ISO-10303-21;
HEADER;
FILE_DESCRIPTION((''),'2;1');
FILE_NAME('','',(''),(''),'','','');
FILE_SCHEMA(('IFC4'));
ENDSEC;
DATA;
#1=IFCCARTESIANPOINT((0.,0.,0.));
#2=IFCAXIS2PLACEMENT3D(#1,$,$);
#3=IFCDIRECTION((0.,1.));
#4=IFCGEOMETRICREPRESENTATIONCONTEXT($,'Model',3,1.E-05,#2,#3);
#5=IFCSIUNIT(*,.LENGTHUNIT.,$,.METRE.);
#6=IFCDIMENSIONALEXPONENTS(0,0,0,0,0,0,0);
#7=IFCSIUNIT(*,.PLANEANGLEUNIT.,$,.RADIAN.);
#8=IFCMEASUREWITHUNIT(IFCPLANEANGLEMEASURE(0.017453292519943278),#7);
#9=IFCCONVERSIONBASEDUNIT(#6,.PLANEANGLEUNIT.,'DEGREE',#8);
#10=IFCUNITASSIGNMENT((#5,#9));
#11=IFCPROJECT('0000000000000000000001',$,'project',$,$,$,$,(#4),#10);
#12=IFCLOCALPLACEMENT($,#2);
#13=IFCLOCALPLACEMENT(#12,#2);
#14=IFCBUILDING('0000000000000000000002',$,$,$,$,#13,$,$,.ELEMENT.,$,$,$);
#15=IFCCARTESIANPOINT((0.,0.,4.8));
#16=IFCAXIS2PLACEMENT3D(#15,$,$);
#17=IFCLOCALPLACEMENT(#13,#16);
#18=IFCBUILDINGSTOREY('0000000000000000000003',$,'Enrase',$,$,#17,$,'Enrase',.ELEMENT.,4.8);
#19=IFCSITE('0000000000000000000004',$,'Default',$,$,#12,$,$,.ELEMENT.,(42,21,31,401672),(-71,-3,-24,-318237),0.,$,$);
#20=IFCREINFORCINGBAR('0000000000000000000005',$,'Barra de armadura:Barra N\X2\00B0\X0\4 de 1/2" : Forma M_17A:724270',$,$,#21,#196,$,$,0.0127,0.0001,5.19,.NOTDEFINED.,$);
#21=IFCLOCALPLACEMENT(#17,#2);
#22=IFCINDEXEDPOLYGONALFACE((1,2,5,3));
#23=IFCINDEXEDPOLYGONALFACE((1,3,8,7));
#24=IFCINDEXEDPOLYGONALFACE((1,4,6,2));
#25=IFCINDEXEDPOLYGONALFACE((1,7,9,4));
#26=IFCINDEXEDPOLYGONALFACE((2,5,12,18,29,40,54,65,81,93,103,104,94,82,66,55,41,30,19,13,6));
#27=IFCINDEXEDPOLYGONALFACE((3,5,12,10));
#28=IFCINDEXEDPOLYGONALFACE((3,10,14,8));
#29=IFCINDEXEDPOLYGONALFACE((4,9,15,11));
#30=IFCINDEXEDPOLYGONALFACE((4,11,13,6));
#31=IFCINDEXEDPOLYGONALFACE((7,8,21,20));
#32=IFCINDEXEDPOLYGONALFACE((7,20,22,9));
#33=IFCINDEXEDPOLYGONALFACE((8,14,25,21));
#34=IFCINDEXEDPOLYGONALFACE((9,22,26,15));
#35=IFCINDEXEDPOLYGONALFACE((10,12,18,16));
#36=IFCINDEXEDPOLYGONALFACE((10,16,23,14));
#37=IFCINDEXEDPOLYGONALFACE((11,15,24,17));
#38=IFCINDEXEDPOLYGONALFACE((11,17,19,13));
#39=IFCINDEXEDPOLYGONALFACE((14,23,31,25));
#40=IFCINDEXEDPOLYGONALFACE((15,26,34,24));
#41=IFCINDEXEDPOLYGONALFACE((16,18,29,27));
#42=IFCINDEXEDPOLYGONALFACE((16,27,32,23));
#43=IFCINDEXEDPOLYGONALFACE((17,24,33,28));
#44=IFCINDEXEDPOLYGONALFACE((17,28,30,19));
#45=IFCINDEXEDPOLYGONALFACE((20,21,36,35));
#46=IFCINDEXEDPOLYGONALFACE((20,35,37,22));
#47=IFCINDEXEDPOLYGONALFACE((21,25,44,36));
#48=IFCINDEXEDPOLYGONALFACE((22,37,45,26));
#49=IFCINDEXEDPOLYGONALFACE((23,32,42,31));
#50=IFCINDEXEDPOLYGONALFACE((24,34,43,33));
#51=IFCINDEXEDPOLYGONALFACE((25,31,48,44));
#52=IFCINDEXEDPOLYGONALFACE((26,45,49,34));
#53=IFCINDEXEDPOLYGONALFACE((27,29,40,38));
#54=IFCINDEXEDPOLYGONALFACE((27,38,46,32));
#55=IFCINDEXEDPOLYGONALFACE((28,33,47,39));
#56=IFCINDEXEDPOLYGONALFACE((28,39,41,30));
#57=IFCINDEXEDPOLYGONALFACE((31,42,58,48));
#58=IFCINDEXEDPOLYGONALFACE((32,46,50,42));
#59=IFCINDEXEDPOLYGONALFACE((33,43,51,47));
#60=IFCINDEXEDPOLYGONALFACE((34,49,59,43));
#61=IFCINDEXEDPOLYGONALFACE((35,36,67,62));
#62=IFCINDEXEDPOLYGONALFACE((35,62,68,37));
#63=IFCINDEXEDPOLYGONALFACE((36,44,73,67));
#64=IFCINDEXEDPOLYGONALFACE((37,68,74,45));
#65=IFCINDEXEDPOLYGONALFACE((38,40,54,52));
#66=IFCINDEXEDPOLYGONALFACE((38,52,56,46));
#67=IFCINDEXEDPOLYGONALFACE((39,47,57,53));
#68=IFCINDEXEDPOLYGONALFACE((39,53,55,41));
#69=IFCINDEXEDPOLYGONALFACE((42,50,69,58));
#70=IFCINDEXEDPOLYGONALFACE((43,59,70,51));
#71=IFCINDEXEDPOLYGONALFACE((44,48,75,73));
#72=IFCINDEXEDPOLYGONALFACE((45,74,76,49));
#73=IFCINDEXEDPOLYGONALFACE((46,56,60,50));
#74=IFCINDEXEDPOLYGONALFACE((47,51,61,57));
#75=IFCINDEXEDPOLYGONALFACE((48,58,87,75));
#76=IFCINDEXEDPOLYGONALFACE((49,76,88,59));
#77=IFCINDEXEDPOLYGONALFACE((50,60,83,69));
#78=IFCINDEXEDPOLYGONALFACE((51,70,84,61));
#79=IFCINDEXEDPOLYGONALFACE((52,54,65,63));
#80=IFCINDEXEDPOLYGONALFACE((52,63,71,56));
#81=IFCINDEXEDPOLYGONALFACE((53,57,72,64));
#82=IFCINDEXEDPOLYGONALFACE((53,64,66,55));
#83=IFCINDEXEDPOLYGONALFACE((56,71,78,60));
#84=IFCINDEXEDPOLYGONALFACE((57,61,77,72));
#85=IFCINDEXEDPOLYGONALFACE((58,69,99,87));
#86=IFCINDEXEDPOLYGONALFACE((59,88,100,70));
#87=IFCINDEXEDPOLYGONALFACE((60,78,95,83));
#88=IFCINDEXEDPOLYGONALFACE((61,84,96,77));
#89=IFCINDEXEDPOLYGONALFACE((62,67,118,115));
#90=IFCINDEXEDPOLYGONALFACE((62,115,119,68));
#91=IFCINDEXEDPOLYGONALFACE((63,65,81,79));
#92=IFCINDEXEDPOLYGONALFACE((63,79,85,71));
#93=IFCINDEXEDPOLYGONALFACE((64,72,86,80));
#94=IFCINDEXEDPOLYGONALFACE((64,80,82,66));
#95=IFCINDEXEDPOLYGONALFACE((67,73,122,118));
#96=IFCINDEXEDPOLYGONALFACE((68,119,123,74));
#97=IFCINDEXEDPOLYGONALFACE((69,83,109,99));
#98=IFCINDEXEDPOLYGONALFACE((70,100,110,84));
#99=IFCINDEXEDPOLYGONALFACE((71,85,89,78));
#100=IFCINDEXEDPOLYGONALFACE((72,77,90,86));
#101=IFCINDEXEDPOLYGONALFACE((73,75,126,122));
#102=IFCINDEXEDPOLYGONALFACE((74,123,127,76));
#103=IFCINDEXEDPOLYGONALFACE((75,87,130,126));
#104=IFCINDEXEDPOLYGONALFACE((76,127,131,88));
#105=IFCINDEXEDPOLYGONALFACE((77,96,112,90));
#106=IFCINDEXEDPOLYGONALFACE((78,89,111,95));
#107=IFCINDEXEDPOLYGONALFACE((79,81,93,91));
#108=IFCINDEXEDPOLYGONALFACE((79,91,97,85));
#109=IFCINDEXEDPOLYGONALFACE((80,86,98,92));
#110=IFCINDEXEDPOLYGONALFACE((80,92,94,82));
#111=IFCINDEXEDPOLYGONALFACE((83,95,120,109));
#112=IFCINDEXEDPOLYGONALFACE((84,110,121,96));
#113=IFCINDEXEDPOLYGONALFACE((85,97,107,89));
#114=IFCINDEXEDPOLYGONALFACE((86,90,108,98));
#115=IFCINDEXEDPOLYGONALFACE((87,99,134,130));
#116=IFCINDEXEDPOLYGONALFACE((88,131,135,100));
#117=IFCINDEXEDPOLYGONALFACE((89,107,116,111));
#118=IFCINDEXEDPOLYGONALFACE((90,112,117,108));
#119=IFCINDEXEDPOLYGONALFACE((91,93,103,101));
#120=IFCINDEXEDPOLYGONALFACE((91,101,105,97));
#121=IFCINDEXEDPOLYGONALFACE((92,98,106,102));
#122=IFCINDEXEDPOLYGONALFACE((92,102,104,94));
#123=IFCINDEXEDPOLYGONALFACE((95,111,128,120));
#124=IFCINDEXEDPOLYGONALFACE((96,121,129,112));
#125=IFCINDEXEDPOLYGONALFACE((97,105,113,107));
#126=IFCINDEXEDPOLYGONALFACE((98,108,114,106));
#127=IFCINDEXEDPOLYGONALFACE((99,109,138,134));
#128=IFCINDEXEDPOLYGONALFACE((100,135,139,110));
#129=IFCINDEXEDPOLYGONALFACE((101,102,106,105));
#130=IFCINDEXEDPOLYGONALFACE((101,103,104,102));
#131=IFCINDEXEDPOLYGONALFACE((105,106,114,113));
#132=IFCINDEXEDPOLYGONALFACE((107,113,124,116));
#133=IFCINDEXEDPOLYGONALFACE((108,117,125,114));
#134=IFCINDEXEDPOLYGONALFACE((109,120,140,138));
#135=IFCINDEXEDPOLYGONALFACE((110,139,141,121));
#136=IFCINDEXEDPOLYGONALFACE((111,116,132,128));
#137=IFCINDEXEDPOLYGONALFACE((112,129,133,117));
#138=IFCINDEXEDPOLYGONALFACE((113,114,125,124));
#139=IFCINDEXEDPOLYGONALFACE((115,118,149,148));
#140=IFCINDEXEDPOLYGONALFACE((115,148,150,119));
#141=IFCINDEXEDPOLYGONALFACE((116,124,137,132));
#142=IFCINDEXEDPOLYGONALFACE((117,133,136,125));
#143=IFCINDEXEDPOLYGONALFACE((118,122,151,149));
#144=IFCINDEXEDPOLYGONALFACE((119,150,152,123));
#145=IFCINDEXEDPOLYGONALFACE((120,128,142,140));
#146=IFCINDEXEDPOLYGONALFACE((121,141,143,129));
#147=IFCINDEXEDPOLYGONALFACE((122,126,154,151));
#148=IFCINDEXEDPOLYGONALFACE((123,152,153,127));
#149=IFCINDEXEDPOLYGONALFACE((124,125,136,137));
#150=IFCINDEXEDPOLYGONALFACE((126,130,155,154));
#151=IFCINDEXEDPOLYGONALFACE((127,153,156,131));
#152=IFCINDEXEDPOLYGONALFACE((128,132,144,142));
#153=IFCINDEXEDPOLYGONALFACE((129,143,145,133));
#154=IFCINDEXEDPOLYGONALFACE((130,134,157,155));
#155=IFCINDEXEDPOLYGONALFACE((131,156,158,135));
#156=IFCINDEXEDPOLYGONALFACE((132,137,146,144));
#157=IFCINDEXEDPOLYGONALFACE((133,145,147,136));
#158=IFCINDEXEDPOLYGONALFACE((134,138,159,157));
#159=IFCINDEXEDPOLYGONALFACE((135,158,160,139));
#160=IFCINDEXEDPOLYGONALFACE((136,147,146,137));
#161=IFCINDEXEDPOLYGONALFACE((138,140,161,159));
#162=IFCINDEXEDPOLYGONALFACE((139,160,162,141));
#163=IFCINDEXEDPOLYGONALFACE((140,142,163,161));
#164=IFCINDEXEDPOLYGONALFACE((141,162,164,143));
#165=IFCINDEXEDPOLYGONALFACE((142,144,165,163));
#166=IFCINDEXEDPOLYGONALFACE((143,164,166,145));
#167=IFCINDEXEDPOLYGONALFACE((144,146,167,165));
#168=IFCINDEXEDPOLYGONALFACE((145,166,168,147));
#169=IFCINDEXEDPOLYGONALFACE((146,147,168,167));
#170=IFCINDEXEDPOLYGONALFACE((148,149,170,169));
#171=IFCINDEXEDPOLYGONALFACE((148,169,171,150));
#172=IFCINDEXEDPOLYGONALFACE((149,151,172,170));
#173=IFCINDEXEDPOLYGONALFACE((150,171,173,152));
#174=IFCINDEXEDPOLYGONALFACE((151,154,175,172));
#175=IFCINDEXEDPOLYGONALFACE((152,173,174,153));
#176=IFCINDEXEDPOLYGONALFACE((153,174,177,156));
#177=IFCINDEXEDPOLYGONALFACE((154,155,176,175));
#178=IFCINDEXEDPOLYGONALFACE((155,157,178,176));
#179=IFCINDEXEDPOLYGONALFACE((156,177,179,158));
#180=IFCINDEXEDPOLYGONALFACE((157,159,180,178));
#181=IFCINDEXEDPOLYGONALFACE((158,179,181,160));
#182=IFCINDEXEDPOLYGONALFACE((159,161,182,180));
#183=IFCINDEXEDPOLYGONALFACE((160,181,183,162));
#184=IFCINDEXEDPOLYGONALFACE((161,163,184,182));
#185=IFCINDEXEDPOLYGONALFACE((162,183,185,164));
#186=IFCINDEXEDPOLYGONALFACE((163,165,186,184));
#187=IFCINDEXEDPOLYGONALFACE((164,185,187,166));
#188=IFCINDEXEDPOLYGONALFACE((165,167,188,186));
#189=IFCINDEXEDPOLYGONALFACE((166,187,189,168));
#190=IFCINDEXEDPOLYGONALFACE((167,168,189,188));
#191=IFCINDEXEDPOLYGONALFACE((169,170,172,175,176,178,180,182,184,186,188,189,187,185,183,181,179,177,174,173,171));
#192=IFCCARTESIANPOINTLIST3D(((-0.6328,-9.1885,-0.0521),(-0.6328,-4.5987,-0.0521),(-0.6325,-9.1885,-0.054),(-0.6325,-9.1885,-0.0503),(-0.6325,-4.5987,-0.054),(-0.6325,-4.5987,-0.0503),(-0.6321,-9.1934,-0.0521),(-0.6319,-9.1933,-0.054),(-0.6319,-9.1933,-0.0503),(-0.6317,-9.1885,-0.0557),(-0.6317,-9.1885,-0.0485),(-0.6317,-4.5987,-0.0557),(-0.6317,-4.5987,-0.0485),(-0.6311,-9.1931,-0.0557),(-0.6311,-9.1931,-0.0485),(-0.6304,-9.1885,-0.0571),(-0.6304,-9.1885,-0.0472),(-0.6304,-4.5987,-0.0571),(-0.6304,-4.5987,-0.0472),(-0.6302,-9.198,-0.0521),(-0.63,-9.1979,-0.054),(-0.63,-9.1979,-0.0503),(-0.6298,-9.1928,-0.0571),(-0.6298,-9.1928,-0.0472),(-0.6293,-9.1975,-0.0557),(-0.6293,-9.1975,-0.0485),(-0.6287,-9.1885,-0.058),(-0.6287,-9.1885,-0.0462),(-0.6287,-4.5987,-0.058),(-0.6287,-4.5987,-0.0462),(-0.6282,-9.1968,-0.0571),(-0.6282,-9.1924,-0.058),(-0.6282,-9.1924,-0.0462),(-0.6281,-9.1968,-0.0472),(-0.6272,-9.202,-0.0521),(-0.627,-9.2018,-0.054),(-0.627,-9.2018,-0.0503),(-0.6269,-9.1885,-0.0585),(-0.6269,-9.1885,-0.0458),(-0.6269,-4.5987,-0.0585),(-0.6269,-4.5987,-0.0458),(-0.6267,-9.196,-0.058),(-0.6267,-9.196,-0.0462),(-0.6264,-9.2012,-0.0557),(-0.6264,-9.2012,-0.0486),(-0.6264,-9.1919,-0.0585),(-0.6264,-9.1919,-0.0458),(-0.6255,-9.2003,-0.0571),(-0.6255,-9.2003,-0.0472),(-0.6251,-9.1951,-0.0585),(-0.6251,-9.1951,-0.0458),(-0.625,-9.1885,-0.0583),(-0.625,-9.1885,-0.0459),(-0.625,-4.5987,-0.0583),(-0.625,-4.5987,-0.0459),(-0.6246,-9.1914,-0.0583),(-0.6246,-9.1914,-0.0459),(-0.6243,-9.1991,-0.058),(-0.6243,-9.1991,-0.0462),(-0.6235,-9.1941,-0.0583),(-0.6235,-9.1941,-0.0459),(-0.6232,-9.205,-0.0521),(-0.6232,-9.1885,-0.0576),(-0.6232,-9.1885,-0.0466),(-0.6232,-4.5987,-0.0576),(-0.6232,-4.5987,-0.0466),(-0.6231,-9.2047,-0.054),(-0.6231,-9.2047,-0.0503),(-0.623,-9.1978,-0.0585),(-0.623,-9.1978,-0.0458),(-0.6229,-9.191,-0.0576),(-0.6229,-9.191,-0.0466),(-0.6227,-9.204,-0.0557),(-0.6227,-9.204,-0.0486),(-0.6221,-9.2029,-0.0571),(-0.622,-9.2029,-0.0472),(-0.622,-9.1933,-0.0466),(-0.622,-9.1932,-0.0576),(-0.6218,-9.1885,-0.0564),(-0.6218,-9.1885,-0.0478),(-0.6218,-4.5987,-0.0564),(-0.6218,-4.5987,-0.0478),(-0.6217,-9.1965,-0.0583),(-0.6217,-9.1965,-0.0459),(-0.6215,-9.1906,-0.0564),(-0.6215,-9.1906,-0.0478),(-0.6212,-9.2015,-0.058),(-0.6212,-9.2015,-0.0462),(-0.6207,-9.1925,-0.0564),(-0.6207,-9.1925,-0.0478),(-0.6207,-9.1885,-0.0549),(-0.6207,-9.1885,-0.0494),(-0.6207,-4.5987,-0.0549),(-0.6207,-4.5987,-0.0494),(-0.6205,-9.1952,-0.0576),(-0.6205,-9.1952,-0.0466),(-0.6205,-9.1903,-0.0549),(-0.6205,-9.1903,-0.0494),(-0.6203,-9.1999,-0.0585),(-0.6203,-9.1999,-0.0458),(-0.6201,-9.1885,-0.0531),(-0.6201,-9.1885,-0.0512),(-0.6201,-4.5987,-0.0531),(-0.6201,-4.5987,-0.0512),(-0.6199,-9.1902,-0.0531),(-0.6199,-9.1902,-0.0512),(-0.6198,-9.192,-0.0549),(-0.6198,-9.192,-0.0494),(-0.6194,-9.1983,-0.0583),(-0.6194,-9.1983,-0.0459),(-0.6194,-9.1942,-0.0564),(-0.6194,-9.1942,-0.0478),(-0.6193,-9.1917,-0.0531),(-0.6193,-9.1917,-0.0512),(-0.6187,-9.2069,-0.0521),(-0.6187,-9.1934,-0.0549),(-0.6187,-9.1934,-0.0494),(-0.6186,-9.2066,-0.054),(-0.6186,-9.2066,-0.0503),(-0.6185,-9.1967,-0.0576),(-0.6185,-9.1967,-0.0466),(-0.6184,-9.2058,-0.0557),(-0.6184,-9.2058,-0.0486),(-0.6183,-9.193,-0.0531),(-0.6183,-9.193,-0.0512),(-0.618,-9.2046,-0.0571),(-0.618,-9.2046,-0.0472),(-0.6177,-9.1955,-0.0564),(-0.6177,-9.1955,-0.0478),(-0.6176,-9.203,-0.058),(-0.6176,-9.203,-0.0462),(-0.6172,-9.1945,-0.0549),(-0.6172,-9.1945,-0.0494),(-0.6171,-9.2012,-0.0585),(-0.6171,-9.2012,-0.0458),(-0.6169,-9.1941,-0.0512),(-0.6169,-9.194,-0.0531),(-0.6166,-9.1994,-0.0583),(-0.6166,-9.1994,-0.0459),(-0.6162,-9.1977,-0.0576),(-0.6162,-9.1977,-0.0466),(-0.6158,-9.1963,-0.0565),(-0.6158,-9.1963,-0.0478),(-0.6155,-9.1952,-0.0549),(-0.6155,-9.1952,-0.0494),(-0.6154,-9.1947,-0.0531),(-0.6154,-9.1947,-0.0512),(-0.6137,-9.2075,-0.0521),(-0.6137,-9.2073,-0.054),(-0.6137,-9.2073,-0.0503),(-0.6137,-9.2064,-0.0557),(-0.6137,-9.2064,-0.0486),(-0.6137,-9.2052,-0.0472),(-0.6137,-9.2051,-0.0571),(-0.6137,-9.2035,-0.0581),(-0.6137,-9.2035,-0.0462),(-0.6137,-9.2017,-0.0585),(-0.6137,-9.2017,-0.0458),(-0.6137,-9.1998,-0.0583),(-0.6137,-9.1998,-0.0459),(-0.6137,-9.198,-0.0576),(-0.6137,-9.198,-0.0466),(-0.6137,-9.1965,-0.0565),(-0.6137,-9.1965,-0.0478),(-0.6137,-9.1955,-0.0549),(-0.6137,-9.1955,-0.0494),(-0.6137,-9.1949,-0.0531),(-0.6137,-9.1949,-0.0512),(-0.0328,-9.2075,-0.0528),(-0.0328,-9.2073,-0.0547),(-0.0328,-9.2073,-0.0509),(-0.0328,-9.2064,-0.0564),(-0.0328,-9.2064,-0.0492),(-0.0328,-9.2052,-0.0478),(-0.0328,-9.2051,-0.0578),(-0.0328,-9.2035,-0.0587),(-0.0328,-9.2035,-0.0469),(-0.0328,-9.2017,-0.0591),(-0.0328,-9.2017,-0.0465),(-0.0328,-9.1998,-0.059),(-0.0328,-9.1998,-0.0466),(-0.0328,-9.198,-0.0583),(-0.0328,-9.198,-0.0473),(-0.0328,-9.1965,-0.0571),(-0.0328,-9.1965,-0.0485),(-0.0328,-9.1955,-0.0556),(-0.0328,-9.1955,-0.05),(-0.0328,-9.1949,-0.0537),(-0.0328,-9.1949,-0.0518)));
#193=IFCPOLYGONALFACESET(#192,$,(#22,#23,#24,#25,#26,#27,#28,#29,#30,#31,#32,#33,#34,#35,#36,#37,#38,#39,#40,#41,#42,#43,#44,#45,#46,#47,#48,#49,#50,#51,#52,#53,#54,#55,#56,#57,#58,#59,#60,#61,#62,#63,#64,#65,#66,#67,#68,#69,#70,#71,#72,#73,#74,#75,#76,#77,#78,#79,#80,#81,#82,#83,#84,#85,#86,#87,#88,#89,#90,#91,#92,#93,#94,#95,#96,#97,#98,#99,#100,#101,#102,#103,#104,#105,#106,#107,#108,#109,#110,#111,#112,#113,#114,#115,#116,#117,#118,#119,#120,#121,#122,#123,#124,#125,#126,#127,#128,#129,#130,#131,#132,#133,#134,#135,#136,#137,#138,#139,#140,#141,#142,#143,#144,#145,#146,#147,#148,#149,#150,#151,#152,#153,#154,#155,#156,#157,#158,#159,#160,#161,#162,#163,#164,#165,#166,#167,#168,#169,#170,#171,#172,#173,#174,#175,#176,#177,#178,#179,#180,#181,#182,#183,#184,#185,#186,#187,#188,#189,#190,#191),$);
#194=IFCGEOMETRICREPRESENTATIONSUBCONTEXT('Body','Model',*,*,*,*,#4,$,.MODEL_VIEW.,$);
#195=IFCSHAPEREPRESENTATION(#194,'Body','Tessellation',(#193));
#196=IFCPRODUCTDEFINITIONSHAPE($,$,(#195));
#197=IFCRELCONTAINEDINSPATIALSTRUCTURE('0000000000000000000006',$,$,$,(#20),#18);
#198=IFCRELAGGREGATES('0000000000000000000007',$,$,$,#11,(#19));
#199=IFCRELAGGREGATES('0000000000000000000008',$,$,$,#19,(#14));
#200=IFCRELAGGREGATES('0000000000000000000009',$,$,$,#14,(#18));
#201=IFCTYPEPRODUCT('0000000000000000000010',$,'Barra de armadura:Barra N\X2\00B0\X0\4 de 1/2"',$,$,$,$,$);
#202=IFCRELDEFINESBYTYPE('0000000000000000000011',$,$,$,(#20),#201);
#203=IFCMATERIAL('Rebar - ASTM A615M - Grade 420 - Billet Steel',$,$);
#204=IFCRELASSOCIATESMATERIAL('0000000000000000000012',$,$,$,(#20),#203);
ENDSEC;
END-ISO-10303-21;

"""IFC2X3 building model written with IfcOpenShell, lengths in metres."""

from ifc_helpers import new_model, entity, si_unit, converted_unit, direction, frame, origin, place, context, subcontext, project, spatial, material, type_object, element, save


model = new_model("IFC2X3")

# Units and contexts
model_context = context("Model", 3, precision=1e-05, world=origin(), true_north=direction((0.0, 1.0)))
body_context = subcontext(model_context, "Body", "Model", "MODEL_VIEW")
ifc_project = project(units=[si_unit("LENGTHUNIT", "METRE"), converted_unit("PLANEANGLEUNIT", "DEGREE", entity("IfcPlaneAngleMeasure", 0.017453292519943278), si_unit("PLANEANGLEUNIT", "RADIAN"), dimensions=[0, 0, 0, 0, 0, 0, 0])], contexts=[model_context])

# Site, building, storey
site_placement = place(None, origin())
site = spatial("IfcSite", under=ifc_project, at=site_placement, Name="Default", CompositionType="ELEMENT", RefLatitude=(42, 21, 31, 401672), RefLongitude=(-71, -3, -24, -318237), RefElevation=0.0)
building_placement = place(site_placement, origin())
building = spatial("IfcBuilding", under=site, at=building_placement, CompositionType="ELEMENT")
storey_placement = place(building_placement, frame((0.0, 0.0, 4.8)))
storey = spatial("IfcBuildingStorey", under=building, at=storey_placement, Name="Enrase", LongName="Enrase", CompositionType="ELEMENT", Elevation=4.8)

# Reinforcing bar
ifc_material = material(Name="Rebar - ASTM A615M - Grade 420 - Billet Steel")
type_product_1 = type_object("IfcTypeProduct", Name="Barra de armadura:Barra N°4 de 1/2\"")
reinforcing_bar_1_placement = place(storey_placement, origin())
element("IfcReinforcingBar", 1, at=reinforcing_bar_1_placement, inside=storey, type_object=type_product_1, material=ifc_material, Name="Barra de armadura:Barra N°4 de 1/2\" : Forma M_17A:724270", BarLength=5.19, BarRole="NOTDEFINED", CrossSectionArea=0.0001, NominalDiameter=0.0127, context=body_context, shape_type="AdvancedSweptSolid", body=[
    entity("IfcSweptDiskSolid", entity("IfcCompositeCurve", [entity("IfcCompositeCurveSegment", "CONTINUOUS", True, entity("IfcPolyline", [entity("IfcCartesianPoint", [-0.6264, -4.5987, -0.0521]), entity("IfcCartesianPoint", [-0.6264, -9.1885, -0.0521])])), entity("IfcCompositeCurveSegment", "CONTINUOUS", True, entity("IfcTrimmedCurve", entity("IfcCircle", entity("IfcAxis2Placement3D", entity("IfcCartesianPoint", [-0.6137, -9.1885, -0.0521]), entity("IfcDirection", [0.001144, 0.0, 0.999999]), entity("IfcDirection", [0.0, -1.0, 0.0])), 0.0127), [entity("IfcParameterValue", 270.0)], [entity("IfcParameterValue", 360.0)], True, "PARAMETER")), entity("IfcCompositeCurveSegment", "CONTINUOUS", True, entity("IfcPolyline", [entity("IfcCartesianPoint", [-0.6137, -9.2012, -0.0521]), entity("IfcCartesianPoint", [-0.0328, -9.2012, -0.0528])]))], False), 0.0063, None, 0.0, 92.0),
])

save(model, "model.ifc")
